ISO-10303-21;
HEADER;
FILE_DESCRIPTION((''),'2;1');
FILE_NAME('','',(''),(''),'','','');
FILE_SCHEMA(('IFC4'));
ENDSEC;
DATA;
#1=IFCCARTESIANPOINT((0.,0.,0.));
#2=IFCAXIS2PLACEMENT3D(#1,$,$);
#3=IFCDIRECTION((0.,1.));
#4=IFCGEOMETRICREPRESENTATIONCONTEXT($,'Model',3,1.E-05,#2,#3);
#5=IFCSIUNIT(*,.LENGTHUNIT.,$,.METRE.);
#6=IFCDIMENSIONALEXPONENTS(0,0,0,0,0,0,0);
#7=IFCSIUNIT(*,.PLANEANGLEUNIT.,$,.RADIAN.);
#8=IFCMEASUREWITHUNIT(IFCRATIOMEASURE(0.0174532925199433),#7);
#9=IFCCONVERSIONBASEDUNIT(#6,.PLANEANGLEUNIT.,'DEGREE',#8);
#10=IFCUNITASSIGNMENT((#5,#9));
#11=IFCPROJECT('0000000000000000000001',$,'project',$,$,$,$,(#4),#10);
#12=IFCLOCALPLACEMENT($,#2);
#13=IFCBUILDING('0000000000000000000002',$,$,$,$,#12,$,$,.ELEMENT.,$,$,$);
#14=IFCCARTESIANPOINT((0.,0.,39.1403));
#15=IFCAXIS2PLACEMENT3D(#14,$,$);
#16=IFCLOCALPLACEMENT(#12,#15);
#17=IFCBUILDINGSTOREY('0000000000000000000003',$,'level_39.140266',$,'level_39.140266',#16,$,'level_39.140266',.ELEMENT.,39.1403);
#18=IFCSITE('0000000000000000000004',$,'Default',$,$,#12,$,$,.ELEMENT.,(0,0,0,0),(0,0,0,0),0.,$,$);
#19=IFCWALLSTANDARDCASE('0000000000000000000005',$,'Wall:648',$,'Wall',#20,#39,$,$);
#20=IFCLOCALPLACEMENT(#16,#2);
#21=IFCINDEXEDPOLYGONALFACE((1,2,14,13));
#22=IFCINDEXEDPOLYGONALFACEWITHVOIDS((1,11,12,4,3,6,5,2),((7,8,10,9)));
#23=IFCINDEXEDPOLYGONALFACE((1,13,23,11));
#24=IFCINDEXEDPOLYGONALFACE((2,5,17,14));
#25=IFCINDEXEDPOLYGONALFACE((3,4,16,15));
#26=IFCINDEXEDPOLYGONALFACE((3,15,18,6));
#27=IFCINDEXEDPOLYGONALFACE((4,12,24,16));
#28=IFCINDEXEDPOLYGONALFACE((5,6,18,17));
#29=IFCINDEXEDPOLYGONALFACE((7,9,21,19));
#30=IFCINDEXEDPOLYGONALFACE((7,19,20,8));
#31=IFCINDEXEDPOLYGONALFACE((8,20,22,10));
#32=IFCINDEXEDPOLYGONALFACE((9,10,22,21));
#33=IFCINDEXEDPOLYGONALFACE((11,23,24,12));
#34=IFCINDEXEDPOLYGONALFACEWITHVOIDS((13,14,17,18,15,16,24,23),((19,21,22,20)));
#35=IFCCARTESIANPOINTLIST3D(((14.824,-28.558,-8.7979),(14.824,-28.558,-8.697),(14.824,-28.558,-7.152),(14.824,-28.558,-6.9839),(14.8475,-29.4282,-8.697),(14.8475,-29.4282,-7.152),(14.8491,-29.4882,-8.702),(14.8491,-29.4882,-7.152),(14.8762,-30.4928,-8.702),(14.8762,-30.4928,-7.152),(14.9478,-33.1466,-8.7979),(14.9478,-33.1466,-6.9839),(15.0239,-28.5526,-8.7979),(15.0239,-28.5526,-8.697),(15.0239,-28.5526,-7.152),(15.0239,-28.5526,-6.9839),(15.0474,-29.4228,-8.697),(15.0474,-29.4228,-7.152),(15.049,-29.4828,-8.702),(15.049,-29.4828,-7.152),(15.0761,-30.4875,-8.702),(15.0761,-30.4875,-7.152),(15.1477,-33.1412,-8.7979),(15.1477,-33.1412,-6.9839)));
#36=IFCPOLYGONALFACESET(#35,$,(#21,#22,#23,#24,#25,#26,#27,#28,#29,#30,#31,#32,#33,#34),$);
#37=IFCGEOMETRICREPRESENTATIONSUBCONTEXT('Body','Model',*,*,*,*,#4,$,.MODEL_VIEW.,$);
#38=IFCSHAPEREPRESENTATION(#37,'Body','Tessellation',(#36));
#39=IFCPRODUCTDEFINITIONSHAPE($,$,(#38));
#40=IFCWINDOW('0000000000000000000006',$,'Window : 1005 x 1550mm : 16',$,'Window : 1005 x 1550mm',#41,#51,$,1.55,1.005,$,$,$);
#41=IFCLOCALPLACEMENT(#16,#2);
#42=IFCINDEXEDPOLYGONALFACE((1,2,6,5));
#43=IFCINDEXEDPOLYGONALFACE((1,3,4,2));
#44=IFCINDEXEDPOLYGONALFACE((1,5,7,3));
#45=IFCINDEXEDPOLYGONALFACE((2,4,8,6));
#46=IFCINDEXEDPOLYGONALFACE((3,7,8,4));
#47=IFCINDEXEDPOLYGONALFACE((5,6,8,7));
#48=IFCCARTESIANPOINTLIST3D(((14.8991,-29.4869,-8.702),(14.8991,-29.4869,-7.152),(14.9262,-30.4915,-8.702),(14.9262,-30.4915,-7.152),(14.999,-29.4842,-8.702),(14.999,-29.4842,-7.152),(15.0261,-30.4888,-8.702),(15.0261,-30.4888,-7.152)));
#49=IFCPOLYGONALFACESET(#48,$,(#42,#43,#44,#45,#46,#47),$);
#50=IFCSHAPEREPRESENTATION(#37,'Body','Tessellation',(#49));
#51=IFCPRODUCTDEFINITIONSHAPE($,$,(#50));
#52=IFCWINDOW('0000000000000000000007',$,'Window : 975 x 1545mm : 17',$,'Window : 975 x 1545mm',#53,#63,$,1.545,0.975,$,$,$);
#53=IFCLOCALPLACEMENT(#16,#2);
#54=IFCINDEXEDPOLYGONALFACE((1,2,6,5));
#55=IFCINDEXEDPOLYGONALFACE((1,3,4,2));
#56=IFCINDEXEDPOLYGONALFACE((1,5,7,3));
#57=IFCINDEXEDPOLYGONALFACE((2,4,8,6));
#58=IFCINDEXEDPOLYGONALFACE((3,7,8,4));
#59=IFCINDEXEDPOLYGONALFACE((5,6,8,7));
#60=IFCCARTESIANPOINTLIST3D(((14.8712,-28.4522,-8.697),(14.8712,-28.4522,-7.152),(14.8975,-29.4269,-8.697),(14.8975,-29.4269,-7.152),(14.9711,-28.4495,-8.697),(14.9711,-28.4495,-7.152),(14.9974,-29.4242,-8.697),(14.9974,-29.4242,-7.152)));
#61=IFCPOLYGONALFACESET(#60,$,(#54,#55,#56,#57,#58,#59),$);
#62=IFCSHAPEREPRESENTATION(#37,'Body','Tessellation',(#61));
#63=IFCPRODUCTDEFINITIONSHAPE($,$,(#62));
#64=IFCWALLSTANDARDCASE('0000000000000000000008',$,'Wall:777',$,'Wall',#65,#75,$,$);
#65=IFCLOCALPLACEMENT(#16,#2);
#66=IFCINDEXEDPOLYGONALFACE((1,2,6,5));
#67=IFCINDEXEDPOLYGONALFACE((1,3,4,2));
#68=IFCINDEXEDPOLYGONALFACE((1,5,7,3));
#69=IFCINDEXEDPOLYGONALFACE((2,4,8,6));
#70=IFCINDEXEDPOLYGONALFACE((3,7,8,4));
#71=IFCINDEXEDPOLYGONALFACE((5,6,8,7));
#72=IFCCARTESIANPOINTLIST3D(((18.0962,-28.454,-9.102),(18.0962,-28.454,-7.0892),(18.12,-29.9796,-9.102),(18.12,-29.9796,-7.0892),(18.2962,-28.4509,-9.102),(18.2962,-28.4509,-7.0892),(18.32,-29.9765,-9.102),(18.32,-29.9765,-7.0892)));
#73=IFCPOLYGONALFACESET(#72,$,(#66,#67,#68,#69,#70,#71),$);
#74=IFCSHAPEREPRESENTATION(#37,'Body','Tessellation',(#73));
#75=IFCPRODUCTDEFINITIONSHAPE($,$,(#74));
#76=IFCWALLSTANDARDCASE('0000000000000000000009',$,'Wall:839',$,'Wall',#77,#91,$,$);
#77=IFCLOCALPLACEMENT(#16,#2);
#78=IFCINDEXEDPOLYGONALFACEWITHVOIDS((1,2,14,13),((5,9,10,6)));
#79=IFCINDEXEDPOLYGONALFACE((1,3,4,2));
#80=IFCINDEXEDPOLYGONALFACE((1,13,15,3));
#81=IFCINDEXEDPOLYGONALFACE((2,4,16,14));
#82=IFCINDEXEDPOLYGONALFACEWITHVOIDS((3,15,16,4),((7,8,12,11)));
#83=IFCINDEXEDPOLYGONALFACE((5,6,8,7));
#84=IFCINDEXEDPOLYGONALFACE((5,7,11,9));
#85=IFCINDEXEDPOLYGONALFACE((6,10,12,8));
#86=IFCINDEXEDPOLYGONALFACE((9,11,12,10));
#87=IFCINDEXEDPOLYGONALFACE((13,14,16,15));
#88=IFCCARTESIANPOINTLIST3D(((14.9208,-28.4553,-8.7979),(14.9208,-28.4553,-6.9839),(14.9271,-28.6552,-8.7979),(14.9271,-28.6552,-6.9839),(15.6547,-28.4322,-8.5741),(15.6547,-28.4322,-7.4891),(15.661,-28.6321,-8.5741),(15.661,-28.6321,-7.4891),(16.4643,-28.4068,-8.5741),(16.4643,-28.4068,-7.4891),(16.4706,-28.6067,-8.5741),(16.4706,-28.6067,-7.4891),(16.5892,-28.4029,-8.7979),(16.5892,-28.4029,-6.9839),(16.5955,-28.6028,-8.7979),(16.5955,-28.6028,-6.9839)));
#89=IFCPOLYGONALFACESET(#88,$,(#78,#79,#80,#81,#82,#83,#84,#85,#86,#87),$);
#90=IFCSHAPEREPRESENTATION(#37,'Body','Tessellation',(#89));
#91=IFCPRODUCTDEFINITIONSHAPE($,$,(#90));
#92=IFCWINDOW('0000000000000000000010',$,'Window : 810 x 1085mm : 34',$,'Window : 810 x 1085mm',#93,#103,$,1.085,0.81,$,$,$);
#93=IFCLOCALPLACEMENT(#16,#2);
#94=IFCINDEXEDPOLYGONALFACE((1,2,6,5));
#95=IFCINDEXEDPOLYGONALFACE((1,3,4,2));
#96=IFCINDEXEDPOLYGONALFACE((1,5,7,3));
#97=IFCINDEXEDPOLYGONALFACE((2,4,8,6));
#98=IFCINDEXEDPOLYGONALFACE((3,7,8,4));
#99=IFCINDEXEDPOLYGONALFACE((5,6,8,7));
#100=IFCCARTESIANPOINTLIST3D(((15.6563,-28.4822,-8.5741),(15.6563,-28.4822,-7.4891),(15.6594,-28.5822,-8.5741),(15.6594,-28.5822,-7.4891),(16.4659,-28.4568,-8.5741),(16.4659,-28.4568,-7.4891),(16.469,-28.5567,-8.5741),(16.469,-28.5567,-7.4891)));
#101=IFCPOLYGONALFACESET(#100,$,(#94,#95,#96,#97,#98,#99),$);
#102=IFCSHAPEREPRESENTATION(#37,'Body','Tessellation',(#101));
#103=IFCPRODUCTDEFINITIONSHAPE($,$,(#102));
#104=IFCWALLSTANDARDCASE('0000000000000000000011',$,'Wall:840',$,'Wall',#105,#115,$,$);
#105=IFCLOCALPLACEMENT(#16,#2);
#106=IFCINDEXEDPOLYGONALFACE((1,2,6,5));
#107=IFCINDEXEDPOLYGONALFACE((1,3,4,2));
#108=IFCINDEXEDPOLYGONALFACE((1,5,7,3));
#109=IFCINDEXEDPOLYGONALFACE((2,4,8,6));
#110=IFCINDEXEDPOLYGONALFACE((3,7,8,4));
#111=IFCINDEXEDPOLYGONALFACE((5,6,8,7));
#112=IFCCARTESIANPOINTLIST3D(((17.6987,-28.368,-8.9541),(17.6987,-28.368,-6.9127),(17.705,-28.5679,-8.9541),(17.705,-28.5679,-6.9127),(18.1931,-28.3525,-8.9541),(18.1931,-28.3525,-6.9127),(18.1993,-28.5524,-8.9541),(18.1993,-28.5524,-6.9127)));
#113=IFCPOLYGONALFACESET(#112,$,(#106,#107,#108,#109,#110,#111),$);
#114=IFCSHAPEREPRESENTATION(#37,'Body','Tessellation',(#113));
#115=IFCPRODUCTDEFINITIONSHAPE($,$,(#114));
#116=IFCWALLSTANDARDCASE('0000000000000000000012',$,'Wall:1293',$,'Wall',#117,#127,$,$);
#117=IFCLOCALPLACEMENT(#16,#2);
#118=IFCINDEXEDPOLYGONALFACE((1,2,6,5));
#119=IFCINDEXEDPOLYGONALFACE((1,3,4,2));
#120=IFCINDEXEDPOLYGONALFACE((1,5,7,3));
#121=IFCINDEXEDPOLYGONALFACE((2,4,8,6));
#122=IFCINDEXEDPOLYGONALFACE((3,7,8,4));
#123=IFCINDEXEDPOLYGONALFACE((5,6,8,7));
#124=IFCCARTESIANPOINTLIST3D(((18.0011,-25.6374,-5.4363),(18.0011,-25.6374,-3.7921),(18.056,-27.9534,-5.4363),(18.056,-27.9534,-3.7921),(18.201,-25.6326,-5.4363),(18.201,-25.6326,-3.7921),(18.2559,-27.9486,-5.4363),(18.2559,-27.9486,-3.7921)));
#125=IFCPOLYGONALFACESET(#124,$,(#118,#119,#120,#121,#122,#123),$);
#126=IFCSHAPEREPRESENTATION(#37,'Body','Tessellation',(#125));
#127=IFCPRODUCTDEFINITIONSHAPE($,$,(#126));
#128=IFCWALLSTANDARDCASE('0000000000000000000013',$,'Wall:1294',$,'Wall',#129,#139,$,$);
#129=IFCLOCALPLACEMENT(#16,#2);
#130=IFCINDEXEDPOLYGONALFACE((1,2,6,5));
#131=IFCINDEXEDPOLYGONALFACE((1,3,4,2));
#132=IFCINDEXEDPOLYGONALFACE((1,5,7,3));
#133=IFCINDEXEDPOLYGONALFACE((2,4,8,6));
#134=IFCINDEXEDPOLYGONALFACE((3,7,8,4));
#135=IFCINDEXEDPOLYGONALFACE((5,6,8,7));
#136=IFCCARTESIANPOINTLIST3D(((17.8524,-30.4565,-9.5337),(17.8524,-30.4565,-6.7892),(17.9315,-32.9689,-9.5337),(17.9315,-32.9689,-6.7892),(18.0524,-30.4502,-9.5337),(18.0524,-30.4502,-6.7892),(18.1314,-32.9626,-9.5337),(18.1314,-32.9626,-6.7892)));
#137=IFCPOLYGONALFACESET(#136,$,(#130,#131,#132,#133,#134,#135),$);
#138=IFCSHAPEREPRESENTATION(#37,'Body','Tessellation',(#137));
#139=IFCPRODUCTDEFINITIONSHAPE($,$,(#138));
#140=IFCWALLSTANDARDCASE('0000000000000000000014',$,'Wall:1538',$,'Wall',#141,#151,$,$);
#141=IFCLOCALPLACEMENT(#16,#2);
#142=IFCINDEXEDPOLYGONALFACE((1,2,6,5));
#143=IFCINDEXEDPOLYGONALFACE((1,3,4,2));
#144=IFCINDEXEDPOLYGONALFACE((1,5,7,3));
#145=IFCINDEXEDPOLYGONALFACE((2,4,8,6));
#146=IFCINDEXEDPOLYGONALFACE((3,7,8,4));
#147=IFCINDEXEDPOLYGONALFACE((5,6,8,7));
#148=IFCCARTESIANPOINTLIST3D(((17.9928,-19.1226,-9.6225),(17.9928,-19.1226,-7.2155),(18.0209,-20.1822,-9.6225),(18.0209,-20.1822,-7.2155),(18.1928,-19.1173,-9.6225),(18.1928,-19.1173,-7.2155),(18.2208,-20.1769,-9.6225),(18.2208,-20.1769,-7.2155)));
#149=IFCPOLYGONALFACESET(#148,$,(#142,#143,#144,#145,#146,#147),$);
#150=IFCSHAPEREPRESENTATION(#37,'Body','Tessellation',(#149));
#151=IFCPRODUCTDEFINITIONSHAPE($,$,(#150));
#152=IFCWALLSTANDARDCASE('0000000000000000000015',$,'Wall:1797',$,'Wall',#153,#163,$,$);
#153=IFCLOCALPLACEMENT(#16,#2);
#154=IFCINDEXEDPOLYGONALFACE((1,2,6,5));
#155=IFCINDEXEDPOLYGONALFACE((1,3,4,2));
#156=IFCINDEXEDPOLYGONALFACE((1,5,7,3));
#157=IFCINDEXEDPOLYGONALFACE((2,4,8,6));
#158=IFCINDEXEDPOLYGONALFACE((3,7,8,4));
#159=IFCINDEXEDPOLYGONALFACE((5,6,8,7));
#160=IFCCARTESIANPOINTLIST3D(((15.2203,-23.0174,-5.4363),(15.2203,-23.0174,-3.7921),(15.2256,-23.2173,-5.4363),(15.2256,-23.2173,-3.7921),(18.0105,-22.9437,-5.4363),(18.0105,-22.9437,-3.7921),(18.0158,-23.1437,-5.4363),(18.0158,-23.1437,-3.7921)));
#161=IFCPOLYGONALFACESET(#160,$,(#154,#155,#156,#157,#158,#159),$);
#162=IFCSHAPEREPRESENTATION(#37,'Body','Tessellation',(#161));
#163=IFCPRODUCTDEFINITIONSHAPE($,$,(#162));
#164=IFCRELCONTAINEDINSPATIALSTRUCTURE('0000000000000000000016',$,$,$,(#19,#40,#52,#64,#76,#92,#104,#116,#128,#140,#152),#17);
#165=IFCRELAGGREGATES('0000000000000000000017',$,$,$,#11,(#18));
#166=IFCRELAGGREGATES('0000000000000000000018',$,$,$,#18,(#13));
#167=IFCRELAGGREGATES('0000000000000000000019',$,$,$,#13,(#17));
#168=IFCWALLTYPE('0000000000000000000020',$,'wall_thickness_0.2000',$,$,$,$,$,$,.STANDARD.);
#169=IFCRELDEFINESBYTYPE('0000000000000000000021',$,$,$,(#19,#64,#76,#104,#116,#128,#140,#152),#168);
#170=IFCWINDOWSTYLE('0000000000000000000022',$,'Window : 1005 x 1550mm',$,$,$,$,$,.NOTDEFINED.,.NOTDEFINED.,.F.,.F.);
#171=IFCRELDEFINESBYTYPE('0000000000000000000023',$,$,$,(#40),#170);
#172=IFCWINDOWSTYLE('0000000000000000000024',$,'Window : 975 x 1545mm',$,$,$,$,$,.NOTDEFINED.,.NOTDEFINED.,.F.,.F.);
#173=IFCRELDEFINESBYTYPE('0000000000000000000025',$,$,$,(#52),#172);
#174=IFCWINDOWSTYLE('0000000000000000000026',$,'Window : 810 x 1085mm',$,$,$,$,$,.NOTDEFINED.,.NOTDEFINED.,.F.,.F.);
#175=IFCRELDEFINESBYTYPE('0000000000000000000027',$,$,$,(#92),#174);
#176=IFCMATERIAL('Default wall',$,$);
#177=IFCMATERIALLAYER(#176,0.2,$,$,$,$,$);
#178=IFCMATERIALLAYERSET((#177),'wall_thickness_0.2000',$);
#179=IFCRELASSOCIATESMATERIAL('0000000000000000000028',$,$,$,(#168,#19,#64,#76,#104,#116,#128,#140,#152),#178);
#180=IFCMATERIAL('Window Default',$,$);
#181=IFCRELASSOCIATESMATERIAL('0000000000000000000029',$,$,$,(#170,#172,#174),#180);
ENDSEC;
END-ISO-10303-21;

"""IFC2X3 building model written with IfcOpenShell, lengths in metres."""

from ifc_helpers import new_model, entity, si_unit, converted_unit, direction, frame, frame_2d, origin, origin_2d_with_axis, place, context, subcontext, project, spatial, polyline, rectangle, outline, extrude, source, transform, mapped, material, layer, layer_set, layer_usage, type_object, type_shapes, element, fill, save


model = new_model("IFC2X3")

# Units and contexts
model_context = context("Model", 3, precision=1e-05, world=origin(), true_north=direction((0.0, 1.0)))
body_context = subcontext(model_context, "Body", "Model", "MODEL_VIEW")
ifc_project = project(units=[si_unit("LENGTHUNIT", "METRE"), converted_unit("PLANEANGLEUNIT", "DEGREE", entity("IfcRatioMeasure", 0.0174532925199433), si_unit("PLANEANGLEUNIT", "RADIAN"), dimensions=[0, 0, 0, 0, 0, 0, 0])], contexts=[model_context])

# Site, building, storey
placement_1 = place(None, origin())
site = spatial("IfcSite", under=ifc_project, at=placement_1, Name="Default", CompositionType="ELEMENT", RefLatitude=(0, 0, 0, 0), RefLongitude=(0, 0, 0, 0), RefElevation=0.0)
building = spatial("IfcBuilding", under=site, at=placement_1, CompositionType="ELEMENT")
storey_placement = place(placement_1, frame((0.0, 0.0, 39.1403)))
storey = spatial("IfcBuildingStorey", under=building, at=storey_placement, Name="level_39.140266", ObjectType="level_39.140266", LongName="level_39.140266", CompositionType="ELEMENT", Elevation=39.1403)

# Shared definitions
ifc_material_1 = material(Name="Default wall")
ifc_layer = layer(ifc_material_1, 0.2)
ifc_layer_set = layer_set([ifc_layer], Name="wall_thickness_0.2000")
ifc_layer_usage = layer_usage(ifc_layer_set, "AXIS2", "POSITIVE", -0.1)
wall_type = type_object("IfcWallType", Name="wall_thickness_0.2000", PredefinedType="STANDARD", material=ifc_layer_set)
ifc_material_2 = material(Name="Window Default")

# Wall, openings, windows
placement_2 = place(placement_1, frame((0.0, 0.0, 30.3424)))
wall_1_placement = place(placement_2, frame((15.0477, -33.1439, 0.0), z_axis=(0.0, 0.0, 1.0), x_axis=(-0.026958, 0.999637, 0.0)))
wall_1 = element("IfcWallStandardCase", 1, at=wall_1_placement, inside=storey, type_object=wall_type, material=ifc_layer_usage, Name="Wall:648", ObjectType="Wall", context=body_context, shape_type="SweptSolid", body=[
    extrude(outline(polyline([(4.5903, -0.1), (4.5903, 0.1), (0.0, 0.1), (0.0, -0.1), (4.5903, -0.1)])), origin(), (0.0, 0.0, 1.0), 1.8141),
])
opening_1_placement = place(wall_1_placement, frame((2.6547, -0.1, 0.0959)))
opening_1 = element("IfcOpeningElement", 2, at=opening_1_placement, cuts=wall_1, ObjectType="Opening", context=body_context, shape_type="SweptSolid", body=[
    extrude(rectangle(XDim=1.005, YDim=1.55, at=frame_2d((0.775, 0.5025), x_axis=(0.0, 1.0))), frame((0.0, 0.0, 0.0), z_axis=(0.0, 1.0, 0.0), x_axis=(0.0, 0.0, 1.0)), (0.0, 0.0, 1.0), 0.2),
])
opening_2_placement = place(wall_1_placement, frame((3.7197, -0.1, 0.1009)))
opening_2 = element("IfcOpeningElement", 3, at=opening_2_placement, cuts=wall_1, ObjectType="Opening", context=body_context, shape_type="SweptSolid", body=[
    extrude(rectangle(XDim=0.975, YDim=1.545, at=frame_2d((0.7725, 0.4875), x_axis=(0.0, 1.0))), frame((0.0, 0.0, 0.0), z_axis=(0.0, 1.0, 0.0), x_axis=(0.0, 0.0, 1.0)), (0.0, 0.0, 1.0), 0.2),
])
window_style_1 = type_object("IfcWindowStyle", Name="Window : 1005 x 1550mm", ConstructionType="NOTDEFINED", OperationType="NOTDEFINED", ParameterTakesPrecedence=False, Sizeable=False, material=ifc_material_2)
shared_shape_1 = source(origin(), body_context, "Body", "SweptSolid", [
    extrude(rectangle(XDim=0.1, YDim=1.005, at=origin_2d_with_axis()), frame((0.5025, 0.1, 0.0), z_axis=(0.0, 0.0, 1.0), x_axis=(0.0, 1.0, 0.0)), (0.0, 0.0, 1.0), 1.55),
])
type_shapes(window_style_1, [shared_shape_1])
window_1_placement = place(opening_1_placement, origin())
window_1 = element("IfcWindow", 4, at=window_1_placement, inside=storey, type_object=window_style_1, Name="Window : 1005 x 1550mm : 16", ObjectType="Window : 1005 x 1550mm", OverallHeight=1.55, OverallWidth=1.005, context=body_context, shape_type="MappedRepresentation", body=[
    mapped(shared_shape_1, transform((0.0, 0.0, 0.0), scale=1.0)),
])
fill(opening_1, window_1)
window_style_2 = type_object("IfcWindowStyle", Name="Window : 975 x 1545mm", ConstructionType="NOTDEFINED", OperationType="NOTDEFINED", ParameterTakesPrecedence=False, Sizeable=False, material=ifc_material_2)
shared_shape_2 = source(origin(), body_context, "Body", "SweptSolid", [
    extrude(rectangle(XDim=0.1, YDim=0.975, at=origin_2d_with_axis()), frame((0.4875, 0.1, 0.0), z_axis=(0.0, 0.0, 1.0), x_axis=(0.0, 1.0, 0.0)), (0.0, 0.0, 1.0), 1.545),
])
type_shapes(window_style_2, [shared_shape_2])
window_2_placement = place(opening_2_placement, origin())
window_2 = element("IfcWindow", 5, at=window_2_placement, inside=storey, type_object=window_style_2, Name="Window : 975 x 1545mm : 17", ObjectType="Window : 975 x 1545mm", OverallHeight=1.545, OverallWidth=0.975, context=body_context, shape_type="MappedRepresentation", body=[
    mapped(shared_shape_2, transform((0.0, 0.0, 0.0), scale=1.0)),
])
fill(opening_2, window_2)

# Wall
placement_3 = place(placement_1, frame((0.0, 0.0, 30.0383)))
wall_2_placement = place(placement_3, frame((18.22, -29.9781, 0.0), z_axis=(0.0, 0.0, 1.0), x_axis=(-0.015619, 0.999878, 0.0)))
element("IfcWallStandardCase", 6, at=wall_2_placement, inside=storey, type_object=wall_type, material=ifc_layer_usage, Name="Wall:777", ObjectType="Wall", context=body_context, shape_type="SweptSolid", body=[
    extrude(outline(polyline([(1.5258, -0.1), (1.5258, 0.1), (0.0, 0.1), (0.0, -0.1), (1.5258, -0.1)])), origin(), (0.0, 0.0, 1.0), 2.0128),
])

# Wall, opening, window
placement_4 = place(placement_1, frame((0.0, 0.0, 30.3424)))
wall_3_placement = place(placement_4, frame((14.924, -28.5553, 0.0), z_axis=(0.0, 0.0, 1.0), x_axis=(0.999506, 0.031413, 0.0)))
wall_3 = element("IfcWallStandardCase", 7, at=wall_3_placement, inside=storey, type_object=wall_type, material=ifc_layer_usage, Name="Wall:839", ObjectType="Wall", context=body_context, shape_type="SweptSolid", body=[
    extrude(outline(polyline([(1.6692, -0.1), (1.6692, 0.1), (0.0, 0.1), (0.0, -0.1), (1.6692, -0.1)])), origin(), (0.0, 0.0, 1.0), 1.8141),
])
opening_3_placement = place(wall_3_placement, frame((0.7342, -0.1, 0.2238)))
opening_3 = element("IfcOpeningElement", 8, at=opening_3_placement, cuts=wall_3, ObjectType="Opening", context=body_context, shape_type="SweptSolid", body=[
    extrude(rectangle(XDim=0.81, YDim=1.085, at=frame_2d((0.5425, 0.405), x_axis=(0.0, 1.0))), frame((0.0, 0.0, 0.0), z_axis=(0.0, 1.0, 0.0), x_axis=(0.0, 0.0, 1.0)), (0.0, 0.0, 1.0), 0.2),
])
window_style_3 = type_object("IfcWindowStyle", Name="Window : 810 x 1085mm", ConstructionType="NOTDEFINED", OperationType="NOTDEFINED", ParameterTakesPrecedence=False, Sizeable=False, material=ifc_material_2)
shared_shape_3 = source(origin(), body_context, "Body", "SweptSolid", [
    extrude(rectangle(XDim=0.1, YDim=0.81, at=origin_2d_with_axis()), frame((0.405, 0.1, 0.0), z_axis=(0.0, 0.0, 1.0), x_axis=(0.0, 1.0, 0.0)), (0.0, 0.0, 1.0), 1.085),
])
type_shapes(window_style_3, [shared_shape_3])
window_3_placement = place(opening_3_placement, origin())
window_3 = element("IfcWindow", 9, at=window_3_placement, inside=storey, type_object=window_style_3, Name="Window : 810 x 1085mm : 34", ObjectType="Window : 810 x 1085mm", OverallHeight=1.085, OverallWidth=0.81, context=body_context, shape_type="MappedRepresentation", body=[
    mapped(shared_shape_3, transform((0.0, 0.0, 0.0), scale=1.0)),
])
fill(opening_3, window_3)

# Walls
placement_5 = place(placement_1, frame((0.0, 0.0, 30.1862)))
wall_4_placement = place(placement_5, frame((17.7018, -28.468, 0.0), z_axis=(0.0, 0.0, 1.0), x_axis=(0.999506, 0.031414, 0.0)))
element("IfcWallStandardCase", 10, at=wall_4_placement, inside=storey, type_object=wall_type, material=ifc_layer_usage, Name="Wall:840", ObjectType="Wall", context=body_context, shape_type="SweptSolid", body=[
    extrude(outline(polyline([(0.4946, -0.1), (0.4946, 0.1), (0.0, 0.1), (0.0, -0.1), (0.4946, -0.1)])), origin(), (0.0, 0.0, 1.0), 2.0414),
])
placement_6 = place(placement_1, frame((0.0, 0.0, 33.704)))
wall_5_placement = place(placement_6, frame((18.156, -27.951, 0.0), z_axis=(0.0, 0.0, 1.0), x_axis=(-0.023704, 0.999719, 0.0)))
element("IfcWallStandardCase", 11, at=wall_5_placement, inside=storey, type_object=wall_type, material=ifc_layer_usage, Name="Wall:1293", ObjectType="Wall", context=body_context, shape_type="SweptSolid", body=[
    extrude(outline(polyline([(2.3167, -0.1), (2.3167, 0.1), (0.0, 0.1), (0.0, -0.1), (2.3167, -0.1)])), origin(), (0.0, 0.0, 1.0), 1.6442),
])
placement_7 = place(placement_1, frame((0.0, 0.0, 29.6066)))
wall_6_placement = place(placement_7, frame((18.0314, -32.9658, 0.0), z_axis=(0.0, 0.0, 1.0), x_axis=(-0.031446, 0.999505, 0.0)))
element("IfcWallStandardCase", 12, at=wall_6_placement, inside=storey, type_object=wall_type, material=ifc_layer_usage, Name="Wall:1294", ObjectType="Wall", context=body_context, shape_type="SweptSolid", body=[
    extrude(outline(polyline([(2.5137, -0.1), (2.5137, 0.1), (0.0, 0.1), (0.0, -0.1), (2.5137, -0.1)])), origin(), (0.0, 0.0, 1.0), 2.7444),
])
placement_8 = place(placement_1, frame((0.0, 0.0, 29.5178)))
wall_7_placement = place(placement_8, frame((18.0928, -19.12, 0.0), z_axis=(0.0, 0.0, 1.0), x_axis=(0.026474, -0.999649, 0.0)))
element("IfcWallStandardCase", 13, at=wall_7_placement, inside=storey, type_object=wall_type, material=ifc_layer_usage, Name="Wall:1538", ObjectType="Wall", context=body_context, shape_type="SweptSolid", body=[
    extrude(outline(polyline([(1.06, -0.1), (1.06, 0.1), (0.0, 0.1), (0.0, -0.1), (1.06, -0.1)])), origin(), (0.0, 0.0, 1.0), 2.4071),
])
placement_9 = place(placement_1, frame((0.0, 0.0, 33.704)))
wall_8_placement = place(placement_9, frame((15.223, -23.1173, 0.0), z_axis=(0.0, 0.0, 1.0), x_axis=(0.999652, 0.026371, 0.0)))
element("IfcWallStandardCase", 14, at=wall_8_placement, inside=storey, type_object=wall_type, material=ifc_layer_usage, Name="Wall:1797", ObjectType="Wall", context=body_context, shape_type="SweptSolid", body=[
    extrude(outline(polyline([(2.7912, -0.1), (2.7912, 0.1), (0.0, 0.1), (0.0, -0.1), (2.7912, -0.1)])), origin(), (0.0, 0.0, 1.0), 1.6442),
])

save(model, "model.ifc")
